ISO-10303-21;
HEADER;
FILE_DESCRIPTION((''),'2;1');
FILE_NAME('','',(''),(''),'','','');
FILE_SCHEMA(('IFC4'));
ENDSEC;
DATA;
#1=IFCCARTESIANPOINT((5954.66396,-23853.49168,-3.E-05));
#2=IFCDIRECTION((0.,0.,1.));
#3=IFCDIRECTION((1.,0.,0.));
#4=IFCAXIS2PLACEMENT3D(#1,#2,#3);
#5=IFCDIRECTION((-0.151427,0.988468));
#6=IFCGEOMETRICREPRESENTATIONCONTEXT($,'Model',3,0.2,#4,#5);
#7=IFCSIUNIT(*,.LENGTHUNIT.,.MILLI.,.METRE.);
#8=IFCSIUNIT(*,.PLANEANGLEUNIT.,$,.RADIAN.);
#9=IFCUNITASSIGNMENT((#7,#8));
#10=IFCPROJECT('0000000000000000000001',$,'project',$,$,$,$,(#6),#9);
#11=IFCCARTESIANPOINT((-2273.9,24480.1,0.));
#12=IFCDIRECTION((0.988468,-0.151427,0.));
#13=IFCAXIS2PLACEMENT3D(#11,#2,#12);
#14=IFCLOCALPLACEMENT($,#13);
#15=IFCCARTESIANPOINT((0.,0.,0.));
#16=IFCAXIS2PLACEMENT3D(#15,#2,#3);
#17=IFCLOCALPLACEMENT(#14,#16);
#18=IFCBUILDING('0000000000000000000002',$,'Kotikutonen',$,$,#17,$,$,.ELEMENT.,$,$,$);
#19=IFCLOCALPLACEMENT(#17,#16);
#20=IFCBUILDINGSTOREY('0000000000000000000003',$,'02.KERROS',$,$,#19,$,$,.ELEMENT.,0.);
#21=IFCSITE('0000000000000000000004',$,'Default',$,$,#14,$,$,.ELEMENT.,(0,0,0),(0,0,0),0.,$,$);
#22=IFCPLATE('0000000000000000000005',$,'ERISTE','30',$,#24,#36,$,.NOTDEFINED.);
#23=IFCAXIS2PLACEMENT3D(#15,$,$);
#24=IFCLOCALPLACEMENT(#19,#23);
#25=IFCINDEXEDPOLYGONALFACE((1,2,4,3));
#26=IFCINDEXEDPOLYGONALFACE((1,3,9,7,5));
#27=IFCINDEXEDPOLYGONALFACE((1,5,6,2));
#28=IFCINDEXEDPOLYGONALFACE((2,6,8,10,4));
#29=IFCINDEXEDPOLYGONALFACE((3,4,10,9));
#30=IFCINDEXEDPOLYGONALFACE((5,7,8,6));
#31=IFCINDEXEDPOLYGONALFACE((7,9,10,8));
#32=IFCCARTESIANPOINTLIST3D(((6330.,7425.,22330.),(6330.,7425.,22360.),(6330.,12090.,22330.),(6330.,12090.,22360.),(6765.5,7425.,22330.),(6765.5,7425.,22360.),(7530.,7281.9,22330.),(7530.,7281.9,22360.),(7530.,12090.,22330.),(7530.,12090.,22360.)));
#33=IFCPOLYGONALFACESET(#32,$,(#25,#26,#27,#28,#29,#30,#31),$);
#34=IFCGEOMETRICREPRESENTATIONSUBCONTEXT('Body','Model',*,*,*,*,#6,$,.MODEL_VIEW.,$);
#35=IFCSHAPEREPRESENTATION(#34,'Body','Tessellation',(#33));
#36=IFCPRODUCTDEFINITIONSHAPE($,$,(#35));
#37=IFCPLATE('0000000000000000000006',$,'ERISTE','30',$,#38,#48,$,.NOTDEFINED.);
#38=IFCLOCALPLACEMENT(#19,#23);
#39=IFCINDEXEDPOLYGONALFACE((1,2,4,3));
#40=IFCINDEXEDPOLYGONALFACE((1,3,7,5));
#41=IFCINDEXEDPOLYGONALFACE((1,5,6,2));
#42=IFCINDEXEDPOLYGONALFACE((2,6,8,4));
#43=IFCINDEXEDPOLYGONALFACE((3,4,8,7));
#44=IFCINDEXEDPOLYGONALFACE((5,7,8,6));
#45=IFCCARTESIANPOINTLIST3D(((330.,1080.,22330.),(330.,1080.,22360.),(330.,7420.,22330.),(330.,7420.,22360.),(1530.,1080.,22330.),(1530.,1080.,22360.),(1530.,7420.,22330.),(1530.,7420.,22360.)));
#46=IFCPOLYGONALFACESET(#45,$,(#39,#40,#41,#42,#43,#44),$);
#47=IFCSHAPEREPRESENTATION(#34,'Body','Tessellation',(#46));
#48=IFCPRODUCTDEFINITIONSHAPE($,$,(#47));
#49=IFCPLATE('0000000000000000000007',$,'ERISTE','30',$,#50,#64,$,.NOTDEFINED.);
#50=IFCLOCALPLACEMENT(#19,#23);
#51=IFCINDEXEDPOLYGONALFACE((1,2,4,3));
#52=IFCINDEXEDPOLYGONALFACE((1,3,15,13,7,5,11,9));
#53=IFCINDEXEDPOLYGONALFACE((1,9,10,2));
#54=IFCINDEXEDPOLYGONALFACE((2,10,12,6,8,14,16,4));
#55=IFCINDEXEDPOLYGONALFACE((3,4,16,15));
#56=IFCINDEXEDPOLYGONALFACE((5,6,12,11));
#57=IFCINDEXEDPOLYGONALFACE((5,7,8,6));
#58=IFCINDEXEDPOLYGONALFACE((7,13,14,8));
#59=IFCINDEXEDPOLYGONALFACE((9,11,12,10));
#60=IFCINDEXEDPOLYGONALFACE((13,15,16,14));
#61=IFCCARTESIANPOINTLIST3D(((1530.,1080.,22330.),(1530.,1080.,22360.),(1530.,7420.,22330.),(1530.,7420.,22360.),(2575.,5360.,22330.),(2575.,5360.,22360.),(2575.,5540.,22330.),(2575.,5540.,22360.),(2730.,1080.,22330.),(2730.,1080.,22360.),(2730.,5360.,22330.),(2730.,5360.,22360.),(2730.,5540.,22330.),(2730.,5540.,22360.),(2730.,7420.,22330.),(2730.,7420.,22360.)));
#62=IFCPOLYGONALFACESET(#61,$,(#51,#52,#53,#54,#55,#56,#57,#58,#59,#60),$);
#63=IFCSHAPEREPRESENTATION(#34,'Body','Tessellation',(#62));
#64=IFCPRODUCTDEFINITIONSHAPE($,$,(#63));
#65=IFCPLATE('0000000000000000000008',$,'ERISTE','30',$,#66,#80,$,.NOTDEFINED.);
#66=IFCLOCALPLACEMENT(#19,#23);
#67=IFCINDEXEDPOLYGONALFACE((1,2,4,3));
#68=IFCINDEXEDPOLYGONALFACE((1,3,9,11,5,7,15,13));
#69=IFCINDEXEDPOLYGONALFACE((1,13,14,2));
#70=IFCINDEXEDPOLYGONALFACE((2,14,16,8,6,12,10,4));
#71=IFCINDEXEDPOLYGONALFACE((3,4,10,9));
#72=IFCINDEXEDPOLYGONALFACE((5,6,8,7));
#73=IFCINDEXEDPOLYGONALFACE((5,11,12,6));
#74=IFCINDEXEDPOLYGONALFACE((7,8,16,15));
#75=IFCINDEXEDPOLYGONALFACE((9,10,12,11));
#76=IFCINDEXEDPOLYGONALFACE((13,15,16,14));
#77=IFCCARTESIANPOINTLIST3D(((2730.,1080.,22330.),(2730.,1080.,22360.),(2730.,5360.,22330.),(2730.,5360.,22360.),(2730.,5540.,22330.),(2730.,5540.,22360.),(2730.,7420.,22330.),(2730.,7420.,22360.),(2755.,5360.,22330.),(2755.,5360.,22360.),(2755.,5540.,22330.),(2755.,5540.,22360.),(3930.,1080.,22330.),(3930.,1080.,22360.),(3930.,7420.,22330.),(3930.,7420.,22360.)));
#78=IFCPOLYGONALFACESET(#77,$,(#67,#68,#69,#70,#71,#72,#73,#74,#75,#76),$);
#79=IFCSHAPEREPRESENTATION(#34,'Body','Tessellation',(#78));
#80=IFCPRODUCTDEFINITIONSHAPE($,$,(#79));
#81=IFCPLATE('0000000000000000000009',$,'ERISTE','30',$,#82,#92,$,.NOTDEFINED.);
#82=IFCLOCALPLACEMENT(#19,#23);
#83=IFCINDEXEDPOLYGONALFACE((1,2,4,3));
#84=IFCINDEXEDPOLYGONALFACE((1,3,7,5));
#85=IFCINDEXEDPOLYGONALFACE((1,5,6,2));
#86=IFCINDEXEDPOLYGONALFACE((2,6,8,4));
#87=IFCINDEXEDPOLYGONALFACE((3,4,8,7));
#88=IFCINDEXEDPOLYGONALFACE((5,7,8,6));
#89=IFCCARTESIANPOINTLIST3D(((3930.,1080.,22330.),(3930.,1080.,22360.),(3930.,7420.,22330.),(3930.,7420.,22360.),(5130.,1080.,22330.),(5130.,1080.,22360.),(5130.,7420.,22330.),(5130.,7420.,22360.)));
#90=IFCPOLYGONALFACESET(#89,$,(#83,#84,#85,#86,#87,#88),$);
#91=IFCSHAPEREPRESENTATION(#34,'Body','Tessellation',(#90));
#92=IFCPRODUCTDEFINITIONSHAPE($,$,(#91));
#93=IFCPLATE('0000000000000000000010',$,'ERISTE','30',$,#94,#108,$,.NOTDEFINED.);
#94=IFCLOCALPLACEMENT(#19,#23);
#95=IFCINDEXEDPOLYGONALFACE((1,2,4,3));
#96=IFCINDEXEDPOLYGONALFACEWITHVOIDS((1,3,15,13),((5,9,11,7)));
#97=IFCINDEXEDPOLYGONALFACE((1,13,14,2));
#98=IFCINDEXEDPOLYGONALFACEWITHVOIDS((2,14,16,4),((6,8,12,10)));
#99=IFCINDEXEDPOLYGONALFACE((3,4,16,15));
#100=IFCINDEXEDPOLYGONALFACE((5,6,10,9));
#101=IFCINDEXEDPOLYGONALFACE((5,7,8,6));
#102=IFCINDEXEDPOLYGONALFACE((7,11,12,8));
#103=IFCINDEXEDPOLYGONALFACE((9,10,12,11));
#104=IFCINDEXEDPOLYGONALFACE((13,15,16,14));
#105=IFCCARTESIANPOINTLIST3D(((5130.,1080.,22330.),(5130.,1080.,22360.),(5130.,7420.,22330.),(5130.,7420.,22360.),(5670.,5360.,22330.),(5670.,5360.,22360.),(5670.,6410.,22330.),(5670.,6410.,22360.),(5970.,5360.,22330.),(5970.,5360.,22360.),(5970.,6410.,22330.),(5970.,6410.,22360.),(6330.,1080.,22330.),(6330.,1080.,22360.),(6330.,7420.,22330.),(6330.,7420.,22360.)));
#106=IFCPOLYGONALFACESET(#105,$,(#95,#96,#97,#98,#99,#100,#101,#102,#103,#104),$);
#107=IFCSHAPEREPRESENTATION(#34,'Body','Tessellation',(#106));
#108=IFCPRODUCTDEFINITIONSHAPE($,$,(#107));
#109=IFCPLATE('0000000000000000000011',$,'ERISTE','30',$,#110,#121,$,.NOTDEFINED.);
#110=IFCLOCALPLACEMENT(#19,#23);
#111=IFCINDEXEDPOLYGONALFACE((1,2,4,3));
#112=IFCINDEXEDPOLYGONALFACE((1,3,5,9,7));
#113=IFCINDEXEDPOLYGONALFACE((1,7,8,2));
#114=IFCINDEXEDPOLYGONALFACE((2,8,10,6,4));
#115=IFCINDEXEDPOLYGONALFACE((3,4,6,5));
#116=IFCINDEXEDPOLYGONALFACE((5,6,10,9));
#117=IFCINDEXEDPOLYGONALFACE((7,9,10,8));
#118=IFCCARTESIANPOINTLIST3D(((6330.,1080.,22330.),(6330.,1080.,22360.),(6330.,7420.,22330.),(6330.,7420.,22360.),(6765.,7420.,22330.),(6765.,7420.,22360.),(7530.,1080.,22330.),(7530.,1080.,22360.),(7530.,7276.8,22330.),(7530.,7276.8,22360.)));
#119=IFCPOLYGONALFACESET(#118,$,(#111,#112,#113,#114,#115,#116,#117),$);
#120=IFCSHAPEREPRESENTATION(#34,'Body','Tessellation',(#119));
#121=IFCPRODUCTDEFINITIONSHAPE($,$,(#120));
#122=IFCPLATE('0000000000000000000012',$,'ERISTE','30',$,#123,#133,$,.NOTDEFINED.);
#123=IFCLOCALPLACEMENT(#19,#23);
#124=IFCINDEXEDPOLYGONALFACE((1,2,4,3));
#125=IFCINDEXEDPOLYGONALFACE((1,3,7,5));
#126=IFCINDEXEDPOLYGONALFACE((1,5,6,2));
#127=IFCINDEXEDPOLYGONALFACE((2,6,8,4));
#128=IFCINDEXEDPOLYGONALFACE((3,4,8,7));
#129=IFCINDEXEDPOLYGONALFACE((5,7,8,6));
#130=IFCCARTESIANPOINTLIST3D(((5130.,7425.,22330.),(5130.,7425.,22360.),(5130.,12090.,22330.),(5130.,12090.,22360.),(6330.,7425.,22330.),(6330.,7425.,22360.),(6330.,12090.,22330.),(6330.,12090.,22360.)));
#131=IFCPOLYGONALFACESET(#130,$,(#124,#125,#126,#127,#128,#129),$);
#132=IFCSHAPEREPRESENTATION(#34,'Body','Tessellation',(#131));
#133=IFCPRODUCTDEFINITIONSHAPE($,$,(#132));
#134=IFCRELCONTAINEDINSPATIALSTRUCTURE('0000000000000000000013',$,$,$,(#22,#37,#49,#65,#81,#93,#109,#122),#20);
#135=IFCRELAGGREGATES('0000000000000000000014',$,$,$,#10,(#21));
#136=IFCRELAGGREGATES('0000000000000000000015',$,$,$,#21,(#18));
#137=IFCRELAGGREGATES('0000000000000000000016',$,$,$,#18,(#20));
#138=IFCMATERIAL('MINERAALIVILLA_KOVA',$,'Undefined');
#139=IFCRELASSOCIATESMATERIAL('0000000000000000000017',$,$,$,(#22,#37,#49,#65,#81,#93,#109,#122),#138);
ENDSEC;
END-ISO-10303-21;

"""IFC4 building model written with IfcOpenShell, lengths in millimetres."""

from ifc_helpers import new_model, si_unit, direction, frame, origin_with_axes, place, context, subcontext, project, spatial, line, indexed_curve, outline, extrude, material, element, save


model = new_model("IFC4")

# Units and contexts
model_context = context("Model", 3, precision=0.2, world=frame((5954.66396, -23853.49168, -3e-05), z_axis=(0.0, 0.0, 1.0), x_axis=(1.0, 0.0, 0.0)), true_north=direction((-0.151427, 0.988468)))
body_context = subcontext(model_context, "Body", "Model", "MODEL_VIEW")
ifc_project = project(units=[si_unit("LENGTHUNIT", "METRE", prefix="MILLI"), si_unit("PLANEANGLEUNIT", "RADIAN")], contexts=[model_context])

# Site, building, storey
site_placement = place(None, frame((-2273.9, 24480.1, 0.0), z_axis=(0.0, 0.0, 1.0), x_axis=(0.988468, -0.151427, 0.0)))
site = spatial("IfcSite", under=ifc_project, at=site_placement, Name="Default", CompositionType="ELEMENT", RefLatitude=(0, 0, 0), RefLongitude=(0, 0, 0), RefElevation=0.0)
building_placement = place(site_placement, origin_with_axes())
building = spatial("IfcBuilding", under=site, at=building_placement, Name="Kotikutonen", CompositionType="ELEMENT")
storey_placement = place(building_placement, origin_with_axes())
storey = spatial("IfcBuildingStorey", under=building, at=storey_placement, Name="02.KERROS", CompositionType="ELEMENT", Elevation=0.0)

# Plates
ifc_material_1 = material(Name="MINERAALIVILLA_KOVA", Category="Undefined")
plate_1_placement = place(storey_placement, frame((6330.0, 7425.0, 22345.0), z_axis=(0.0, 0.0, 1.0), x_axis=(1.0, 0.0, 0.0)))
element("IfcPlate", 1, at=plate_1_placement, inside=storey, material=ifc_material_1, Name="ERISTE", Description="30", PredefinedType="NOTDEFINED", context=body_context, shape_type="SolidModel", body=[
    extrude(outline(indexed_curve([(0.0, 0.0), (435.5, 0.0), (1200.0, -143.1), (1200.0, 4665.0), (0.0, 4665.0)], segments=[line(1, 2, 3, 4, 5, 1)])), frame((0.0, 0.0, 15.0), z_axis=(0.0, 0.0, 1.0), x_axis=(1.0, 0.0, 0.0)), (0.0, 0.0, -1.0), 30.0),
])
plate_2_placement = place(storey_placement, frame((330.0, 1080.0, 22345.0), z_axis=(0.0, 0.0, 1.0), x_axis=(1.0, 0.0, 0.0)))
element("IfcPlate", 2, at=plate_2_placement, inside=storey, material=ifc_material_1, Name="ERISTE", Description="30", PredefinedType="NOTDEFINED", context=body_context, shape_type="SolidModel", body=[
    extrude(outline(indexed_curve([(0.0, 0.0), (1200.0, 0.0), (1200.0, 6340.0), (0.0, 6340.0)], segments=[line(1, 2, 3, 4, 1)])), frame((0.0, 0.0, 15.0), z_axis=(0.0, 0.0, 1.0), x_axis=(1.0, 0.0, 0.0)), (0.0, 0.0, -1.0), 30.0),
])
plate_3_placement = place(storey_placement, frame((1530.0, 1080.0, 22345.0), z_axis=(0.0, 0.0, 1.0), x_axis=(1.0, 0.0, 0.0)))
element("IfcPlate", 3, at=plate_3_placement, inside=storey, material=ifc_material_1, Name="ERISTE", Description="30", PredefinedType="NOTDEFINED", context=body_context, shape_type="SolidModel", body=[
    extrude(outline(indexed_curve([(0.0, 0.0), (1200.0, 0.0), (1200.0, 4280.0), (1045.0, 4280.0), (1045.0, 4460.0), (1200.0, 4460.0), (1200.0, 6340.0), (0.0, 6340.0)], segments=[line(1, 2, 3, 4, 5, 6, 7, 8, 1)])), frame((0.0, 0.0, 15.0), z_axis=(0.0, 0.0, 1.0), x_axis=(1.0, 0.0, 0.0)), (0.0, 0.0, -1.0), 30.0),
])
plate_4_placement = place(storey_placement, frame((2730.0, 1080.0, 22345.0), z_axis=(0.0, 0.0, 1.0), x_axis=(1.0, 0.0, 0.0)))
element("IfcPlate", 4, at=plate_4_placement, inside=storey, material=ifc_material_1, Name="ERISTE", Description="30", PredefinedType="NOTDEFINED", context=body_context, shape_type="SolidModel", body=[
    extrude(outline(indexed_curve([(0.0, 0.0), (1200.0, 0.0), (1200.0, 6340.0), (0.0, 6340.0), (0.0, 4460.0), (25.0, 4460.0), (25.0, 4280.0), (0.0, 4280.0)], segments=[line(1, 2, 3, 4, 5, 6, 7, 8, 1)])), frame((0.0, 0.0, 15.0), z_axis=(0.0, 0.0, 1.0), x_axis=(1.0, 0.0, 0.0)), (0.0, 0.0, -1.0), 30.0),
])
plate_5_placement = place(storey_placement, frame((3930.0, 1080.0, 22345.0), z_axis=(0.0, 0.0, 1.0), x_axis=(1.0, 0.0, 0.0)))
element("IfcPlate", 5, at=plate_5_placement, inside=storey, material=ifc_material_1, Name="ERISTE", Description="30", PredefinedType="NOTDEFINED", context=body_context, shape_type="SolidModel", body=[
    extrude(outline(indexed_curve([(0.0, 0.0), (1200.0, 0.0), (1200.0, 6340.0), (0.0, 6340.0)], segments=[line(1, 2, 3, 4, 1)])), frame((0.0, 0.0, 15.0), z_axis=(0.0, 0.0, 1.0), x_axis=(1.0, 0.0, 0.0)), (0.0, 0.0, -1.0), 30.0),
])

# Plate, voiding feature
plate_6_placement = place(storey_placement, frame((5130.0, 1080.0, 22345.0), z_axis=(0.0, 0.0, 1.0), x_axis=(1.0, 0.0, 0.0)))
plate_6 = element("IfcPlate", 6, at=plate_6_placement, inside=storey, material=ifc_material_1, Name="ERISTE", Description="30", PredefinedType="NOTDEFINED", context=body_context, shape_type="SolidModel", body=[
    extrude(outline(indexed_curve([(0.0, 0.0), (1200.0, 0.0), (1200.0, 6340.0), (0.0, 6340.0)], segments=[line(1, 2, 3, 4, 1)])), frame((0.0, 0.0, 15.0), z_axis=(0.0, 0.0, 1.0), x_axis=(1.0, 0.0, 0.0)), (0.0, 0.0, -1.0), 30.0),
])
voiding_feature_1_placement = place(plate_6_placement, frame((840.0, 5330.0, 0.0), z_axis=(0.0, 0.0, 1.0), x_axis=(-1.0, 0.0, 0.0)))
element("IfcVoidingFeature", 7, at=voiding_feature_1_placement, cuts=plate_6, Name="Opening", PredefinedType="HOLE", context=body_context, shape_type="SolidModel", body=[
    extrude(outline(indexed_curve([(0.0, 0.0), (300.0, 0.0), (300.0, 1050.0), (0.0, 1050.0)], segments=[line(1, 2, 3, 4, 1)])), frame((0.0, 0.0, 90.0), z_axis=(0.0, 0.0, 1.0), x_axis=(1.0, 0.0, 0.0)), (0.0, 0.0, -1.0), 180.0),
])

# Plates
plate_7_placement = place(storey_placement, frame((6330.0, 1080.0, 22345.0), z_axis=(0.0, 0.0, 1.0), x_axis=(1.0, 0.0, 0.0)))
element("IfcPlate", 8, at=plate_7_placement, inside=storey, material=ifc_material_1, Name="ERISTE", Description="30", PredefinedType="NOTDEFINED", context=body_context, shape_type="SolidModel", body=[
    extrude(outline(indexed_curve([(0.0, 0.0), (1200.0, 0.0), (1200.0, 6196.8), (435.0, 6340.0), (0.0, 6340.0)], segments=[line(1, 2, 3, 4, 5, 1)])), frame((0.0, 0.0, 15.0), z_axis=(0.0, 0.0, 1.0), x_axis=(1.0, 0.0, 0.0)), (0.0, 0.0, -1.0), 30.0),
])
plate_8_placement = place(storey_placement, frame((5130.0, 7425.0, 22345.0), z_axis=(0.0, 0.0, 1.0), x_axis=(1.0, 0.0, 0.0)))
element("IfcPlate", 9, at=plate_8_placement, inside=storey, material=ifc_material_1, Name="ERISTE", Description="30", PredefinedType="NOTDEFINED", context=body_context, shape_type="SolidModel", body=[
    extrude(outline(indexed_curve([(0.0, 0.0), (1200.0, 0.0), (1200.0, 4665.0), (0.0, 4665.0)], segments=[line(1, 2, 3, 4, 1)])), frame((0.0, 0.0, 15.0), z_axis=(0.0, 0.0, 1.0), x_axis=(1.0, 0.0, 0.0)), (0.0, 0.0, -1.0), 30.0),
])

save(model, "model.ifc")
